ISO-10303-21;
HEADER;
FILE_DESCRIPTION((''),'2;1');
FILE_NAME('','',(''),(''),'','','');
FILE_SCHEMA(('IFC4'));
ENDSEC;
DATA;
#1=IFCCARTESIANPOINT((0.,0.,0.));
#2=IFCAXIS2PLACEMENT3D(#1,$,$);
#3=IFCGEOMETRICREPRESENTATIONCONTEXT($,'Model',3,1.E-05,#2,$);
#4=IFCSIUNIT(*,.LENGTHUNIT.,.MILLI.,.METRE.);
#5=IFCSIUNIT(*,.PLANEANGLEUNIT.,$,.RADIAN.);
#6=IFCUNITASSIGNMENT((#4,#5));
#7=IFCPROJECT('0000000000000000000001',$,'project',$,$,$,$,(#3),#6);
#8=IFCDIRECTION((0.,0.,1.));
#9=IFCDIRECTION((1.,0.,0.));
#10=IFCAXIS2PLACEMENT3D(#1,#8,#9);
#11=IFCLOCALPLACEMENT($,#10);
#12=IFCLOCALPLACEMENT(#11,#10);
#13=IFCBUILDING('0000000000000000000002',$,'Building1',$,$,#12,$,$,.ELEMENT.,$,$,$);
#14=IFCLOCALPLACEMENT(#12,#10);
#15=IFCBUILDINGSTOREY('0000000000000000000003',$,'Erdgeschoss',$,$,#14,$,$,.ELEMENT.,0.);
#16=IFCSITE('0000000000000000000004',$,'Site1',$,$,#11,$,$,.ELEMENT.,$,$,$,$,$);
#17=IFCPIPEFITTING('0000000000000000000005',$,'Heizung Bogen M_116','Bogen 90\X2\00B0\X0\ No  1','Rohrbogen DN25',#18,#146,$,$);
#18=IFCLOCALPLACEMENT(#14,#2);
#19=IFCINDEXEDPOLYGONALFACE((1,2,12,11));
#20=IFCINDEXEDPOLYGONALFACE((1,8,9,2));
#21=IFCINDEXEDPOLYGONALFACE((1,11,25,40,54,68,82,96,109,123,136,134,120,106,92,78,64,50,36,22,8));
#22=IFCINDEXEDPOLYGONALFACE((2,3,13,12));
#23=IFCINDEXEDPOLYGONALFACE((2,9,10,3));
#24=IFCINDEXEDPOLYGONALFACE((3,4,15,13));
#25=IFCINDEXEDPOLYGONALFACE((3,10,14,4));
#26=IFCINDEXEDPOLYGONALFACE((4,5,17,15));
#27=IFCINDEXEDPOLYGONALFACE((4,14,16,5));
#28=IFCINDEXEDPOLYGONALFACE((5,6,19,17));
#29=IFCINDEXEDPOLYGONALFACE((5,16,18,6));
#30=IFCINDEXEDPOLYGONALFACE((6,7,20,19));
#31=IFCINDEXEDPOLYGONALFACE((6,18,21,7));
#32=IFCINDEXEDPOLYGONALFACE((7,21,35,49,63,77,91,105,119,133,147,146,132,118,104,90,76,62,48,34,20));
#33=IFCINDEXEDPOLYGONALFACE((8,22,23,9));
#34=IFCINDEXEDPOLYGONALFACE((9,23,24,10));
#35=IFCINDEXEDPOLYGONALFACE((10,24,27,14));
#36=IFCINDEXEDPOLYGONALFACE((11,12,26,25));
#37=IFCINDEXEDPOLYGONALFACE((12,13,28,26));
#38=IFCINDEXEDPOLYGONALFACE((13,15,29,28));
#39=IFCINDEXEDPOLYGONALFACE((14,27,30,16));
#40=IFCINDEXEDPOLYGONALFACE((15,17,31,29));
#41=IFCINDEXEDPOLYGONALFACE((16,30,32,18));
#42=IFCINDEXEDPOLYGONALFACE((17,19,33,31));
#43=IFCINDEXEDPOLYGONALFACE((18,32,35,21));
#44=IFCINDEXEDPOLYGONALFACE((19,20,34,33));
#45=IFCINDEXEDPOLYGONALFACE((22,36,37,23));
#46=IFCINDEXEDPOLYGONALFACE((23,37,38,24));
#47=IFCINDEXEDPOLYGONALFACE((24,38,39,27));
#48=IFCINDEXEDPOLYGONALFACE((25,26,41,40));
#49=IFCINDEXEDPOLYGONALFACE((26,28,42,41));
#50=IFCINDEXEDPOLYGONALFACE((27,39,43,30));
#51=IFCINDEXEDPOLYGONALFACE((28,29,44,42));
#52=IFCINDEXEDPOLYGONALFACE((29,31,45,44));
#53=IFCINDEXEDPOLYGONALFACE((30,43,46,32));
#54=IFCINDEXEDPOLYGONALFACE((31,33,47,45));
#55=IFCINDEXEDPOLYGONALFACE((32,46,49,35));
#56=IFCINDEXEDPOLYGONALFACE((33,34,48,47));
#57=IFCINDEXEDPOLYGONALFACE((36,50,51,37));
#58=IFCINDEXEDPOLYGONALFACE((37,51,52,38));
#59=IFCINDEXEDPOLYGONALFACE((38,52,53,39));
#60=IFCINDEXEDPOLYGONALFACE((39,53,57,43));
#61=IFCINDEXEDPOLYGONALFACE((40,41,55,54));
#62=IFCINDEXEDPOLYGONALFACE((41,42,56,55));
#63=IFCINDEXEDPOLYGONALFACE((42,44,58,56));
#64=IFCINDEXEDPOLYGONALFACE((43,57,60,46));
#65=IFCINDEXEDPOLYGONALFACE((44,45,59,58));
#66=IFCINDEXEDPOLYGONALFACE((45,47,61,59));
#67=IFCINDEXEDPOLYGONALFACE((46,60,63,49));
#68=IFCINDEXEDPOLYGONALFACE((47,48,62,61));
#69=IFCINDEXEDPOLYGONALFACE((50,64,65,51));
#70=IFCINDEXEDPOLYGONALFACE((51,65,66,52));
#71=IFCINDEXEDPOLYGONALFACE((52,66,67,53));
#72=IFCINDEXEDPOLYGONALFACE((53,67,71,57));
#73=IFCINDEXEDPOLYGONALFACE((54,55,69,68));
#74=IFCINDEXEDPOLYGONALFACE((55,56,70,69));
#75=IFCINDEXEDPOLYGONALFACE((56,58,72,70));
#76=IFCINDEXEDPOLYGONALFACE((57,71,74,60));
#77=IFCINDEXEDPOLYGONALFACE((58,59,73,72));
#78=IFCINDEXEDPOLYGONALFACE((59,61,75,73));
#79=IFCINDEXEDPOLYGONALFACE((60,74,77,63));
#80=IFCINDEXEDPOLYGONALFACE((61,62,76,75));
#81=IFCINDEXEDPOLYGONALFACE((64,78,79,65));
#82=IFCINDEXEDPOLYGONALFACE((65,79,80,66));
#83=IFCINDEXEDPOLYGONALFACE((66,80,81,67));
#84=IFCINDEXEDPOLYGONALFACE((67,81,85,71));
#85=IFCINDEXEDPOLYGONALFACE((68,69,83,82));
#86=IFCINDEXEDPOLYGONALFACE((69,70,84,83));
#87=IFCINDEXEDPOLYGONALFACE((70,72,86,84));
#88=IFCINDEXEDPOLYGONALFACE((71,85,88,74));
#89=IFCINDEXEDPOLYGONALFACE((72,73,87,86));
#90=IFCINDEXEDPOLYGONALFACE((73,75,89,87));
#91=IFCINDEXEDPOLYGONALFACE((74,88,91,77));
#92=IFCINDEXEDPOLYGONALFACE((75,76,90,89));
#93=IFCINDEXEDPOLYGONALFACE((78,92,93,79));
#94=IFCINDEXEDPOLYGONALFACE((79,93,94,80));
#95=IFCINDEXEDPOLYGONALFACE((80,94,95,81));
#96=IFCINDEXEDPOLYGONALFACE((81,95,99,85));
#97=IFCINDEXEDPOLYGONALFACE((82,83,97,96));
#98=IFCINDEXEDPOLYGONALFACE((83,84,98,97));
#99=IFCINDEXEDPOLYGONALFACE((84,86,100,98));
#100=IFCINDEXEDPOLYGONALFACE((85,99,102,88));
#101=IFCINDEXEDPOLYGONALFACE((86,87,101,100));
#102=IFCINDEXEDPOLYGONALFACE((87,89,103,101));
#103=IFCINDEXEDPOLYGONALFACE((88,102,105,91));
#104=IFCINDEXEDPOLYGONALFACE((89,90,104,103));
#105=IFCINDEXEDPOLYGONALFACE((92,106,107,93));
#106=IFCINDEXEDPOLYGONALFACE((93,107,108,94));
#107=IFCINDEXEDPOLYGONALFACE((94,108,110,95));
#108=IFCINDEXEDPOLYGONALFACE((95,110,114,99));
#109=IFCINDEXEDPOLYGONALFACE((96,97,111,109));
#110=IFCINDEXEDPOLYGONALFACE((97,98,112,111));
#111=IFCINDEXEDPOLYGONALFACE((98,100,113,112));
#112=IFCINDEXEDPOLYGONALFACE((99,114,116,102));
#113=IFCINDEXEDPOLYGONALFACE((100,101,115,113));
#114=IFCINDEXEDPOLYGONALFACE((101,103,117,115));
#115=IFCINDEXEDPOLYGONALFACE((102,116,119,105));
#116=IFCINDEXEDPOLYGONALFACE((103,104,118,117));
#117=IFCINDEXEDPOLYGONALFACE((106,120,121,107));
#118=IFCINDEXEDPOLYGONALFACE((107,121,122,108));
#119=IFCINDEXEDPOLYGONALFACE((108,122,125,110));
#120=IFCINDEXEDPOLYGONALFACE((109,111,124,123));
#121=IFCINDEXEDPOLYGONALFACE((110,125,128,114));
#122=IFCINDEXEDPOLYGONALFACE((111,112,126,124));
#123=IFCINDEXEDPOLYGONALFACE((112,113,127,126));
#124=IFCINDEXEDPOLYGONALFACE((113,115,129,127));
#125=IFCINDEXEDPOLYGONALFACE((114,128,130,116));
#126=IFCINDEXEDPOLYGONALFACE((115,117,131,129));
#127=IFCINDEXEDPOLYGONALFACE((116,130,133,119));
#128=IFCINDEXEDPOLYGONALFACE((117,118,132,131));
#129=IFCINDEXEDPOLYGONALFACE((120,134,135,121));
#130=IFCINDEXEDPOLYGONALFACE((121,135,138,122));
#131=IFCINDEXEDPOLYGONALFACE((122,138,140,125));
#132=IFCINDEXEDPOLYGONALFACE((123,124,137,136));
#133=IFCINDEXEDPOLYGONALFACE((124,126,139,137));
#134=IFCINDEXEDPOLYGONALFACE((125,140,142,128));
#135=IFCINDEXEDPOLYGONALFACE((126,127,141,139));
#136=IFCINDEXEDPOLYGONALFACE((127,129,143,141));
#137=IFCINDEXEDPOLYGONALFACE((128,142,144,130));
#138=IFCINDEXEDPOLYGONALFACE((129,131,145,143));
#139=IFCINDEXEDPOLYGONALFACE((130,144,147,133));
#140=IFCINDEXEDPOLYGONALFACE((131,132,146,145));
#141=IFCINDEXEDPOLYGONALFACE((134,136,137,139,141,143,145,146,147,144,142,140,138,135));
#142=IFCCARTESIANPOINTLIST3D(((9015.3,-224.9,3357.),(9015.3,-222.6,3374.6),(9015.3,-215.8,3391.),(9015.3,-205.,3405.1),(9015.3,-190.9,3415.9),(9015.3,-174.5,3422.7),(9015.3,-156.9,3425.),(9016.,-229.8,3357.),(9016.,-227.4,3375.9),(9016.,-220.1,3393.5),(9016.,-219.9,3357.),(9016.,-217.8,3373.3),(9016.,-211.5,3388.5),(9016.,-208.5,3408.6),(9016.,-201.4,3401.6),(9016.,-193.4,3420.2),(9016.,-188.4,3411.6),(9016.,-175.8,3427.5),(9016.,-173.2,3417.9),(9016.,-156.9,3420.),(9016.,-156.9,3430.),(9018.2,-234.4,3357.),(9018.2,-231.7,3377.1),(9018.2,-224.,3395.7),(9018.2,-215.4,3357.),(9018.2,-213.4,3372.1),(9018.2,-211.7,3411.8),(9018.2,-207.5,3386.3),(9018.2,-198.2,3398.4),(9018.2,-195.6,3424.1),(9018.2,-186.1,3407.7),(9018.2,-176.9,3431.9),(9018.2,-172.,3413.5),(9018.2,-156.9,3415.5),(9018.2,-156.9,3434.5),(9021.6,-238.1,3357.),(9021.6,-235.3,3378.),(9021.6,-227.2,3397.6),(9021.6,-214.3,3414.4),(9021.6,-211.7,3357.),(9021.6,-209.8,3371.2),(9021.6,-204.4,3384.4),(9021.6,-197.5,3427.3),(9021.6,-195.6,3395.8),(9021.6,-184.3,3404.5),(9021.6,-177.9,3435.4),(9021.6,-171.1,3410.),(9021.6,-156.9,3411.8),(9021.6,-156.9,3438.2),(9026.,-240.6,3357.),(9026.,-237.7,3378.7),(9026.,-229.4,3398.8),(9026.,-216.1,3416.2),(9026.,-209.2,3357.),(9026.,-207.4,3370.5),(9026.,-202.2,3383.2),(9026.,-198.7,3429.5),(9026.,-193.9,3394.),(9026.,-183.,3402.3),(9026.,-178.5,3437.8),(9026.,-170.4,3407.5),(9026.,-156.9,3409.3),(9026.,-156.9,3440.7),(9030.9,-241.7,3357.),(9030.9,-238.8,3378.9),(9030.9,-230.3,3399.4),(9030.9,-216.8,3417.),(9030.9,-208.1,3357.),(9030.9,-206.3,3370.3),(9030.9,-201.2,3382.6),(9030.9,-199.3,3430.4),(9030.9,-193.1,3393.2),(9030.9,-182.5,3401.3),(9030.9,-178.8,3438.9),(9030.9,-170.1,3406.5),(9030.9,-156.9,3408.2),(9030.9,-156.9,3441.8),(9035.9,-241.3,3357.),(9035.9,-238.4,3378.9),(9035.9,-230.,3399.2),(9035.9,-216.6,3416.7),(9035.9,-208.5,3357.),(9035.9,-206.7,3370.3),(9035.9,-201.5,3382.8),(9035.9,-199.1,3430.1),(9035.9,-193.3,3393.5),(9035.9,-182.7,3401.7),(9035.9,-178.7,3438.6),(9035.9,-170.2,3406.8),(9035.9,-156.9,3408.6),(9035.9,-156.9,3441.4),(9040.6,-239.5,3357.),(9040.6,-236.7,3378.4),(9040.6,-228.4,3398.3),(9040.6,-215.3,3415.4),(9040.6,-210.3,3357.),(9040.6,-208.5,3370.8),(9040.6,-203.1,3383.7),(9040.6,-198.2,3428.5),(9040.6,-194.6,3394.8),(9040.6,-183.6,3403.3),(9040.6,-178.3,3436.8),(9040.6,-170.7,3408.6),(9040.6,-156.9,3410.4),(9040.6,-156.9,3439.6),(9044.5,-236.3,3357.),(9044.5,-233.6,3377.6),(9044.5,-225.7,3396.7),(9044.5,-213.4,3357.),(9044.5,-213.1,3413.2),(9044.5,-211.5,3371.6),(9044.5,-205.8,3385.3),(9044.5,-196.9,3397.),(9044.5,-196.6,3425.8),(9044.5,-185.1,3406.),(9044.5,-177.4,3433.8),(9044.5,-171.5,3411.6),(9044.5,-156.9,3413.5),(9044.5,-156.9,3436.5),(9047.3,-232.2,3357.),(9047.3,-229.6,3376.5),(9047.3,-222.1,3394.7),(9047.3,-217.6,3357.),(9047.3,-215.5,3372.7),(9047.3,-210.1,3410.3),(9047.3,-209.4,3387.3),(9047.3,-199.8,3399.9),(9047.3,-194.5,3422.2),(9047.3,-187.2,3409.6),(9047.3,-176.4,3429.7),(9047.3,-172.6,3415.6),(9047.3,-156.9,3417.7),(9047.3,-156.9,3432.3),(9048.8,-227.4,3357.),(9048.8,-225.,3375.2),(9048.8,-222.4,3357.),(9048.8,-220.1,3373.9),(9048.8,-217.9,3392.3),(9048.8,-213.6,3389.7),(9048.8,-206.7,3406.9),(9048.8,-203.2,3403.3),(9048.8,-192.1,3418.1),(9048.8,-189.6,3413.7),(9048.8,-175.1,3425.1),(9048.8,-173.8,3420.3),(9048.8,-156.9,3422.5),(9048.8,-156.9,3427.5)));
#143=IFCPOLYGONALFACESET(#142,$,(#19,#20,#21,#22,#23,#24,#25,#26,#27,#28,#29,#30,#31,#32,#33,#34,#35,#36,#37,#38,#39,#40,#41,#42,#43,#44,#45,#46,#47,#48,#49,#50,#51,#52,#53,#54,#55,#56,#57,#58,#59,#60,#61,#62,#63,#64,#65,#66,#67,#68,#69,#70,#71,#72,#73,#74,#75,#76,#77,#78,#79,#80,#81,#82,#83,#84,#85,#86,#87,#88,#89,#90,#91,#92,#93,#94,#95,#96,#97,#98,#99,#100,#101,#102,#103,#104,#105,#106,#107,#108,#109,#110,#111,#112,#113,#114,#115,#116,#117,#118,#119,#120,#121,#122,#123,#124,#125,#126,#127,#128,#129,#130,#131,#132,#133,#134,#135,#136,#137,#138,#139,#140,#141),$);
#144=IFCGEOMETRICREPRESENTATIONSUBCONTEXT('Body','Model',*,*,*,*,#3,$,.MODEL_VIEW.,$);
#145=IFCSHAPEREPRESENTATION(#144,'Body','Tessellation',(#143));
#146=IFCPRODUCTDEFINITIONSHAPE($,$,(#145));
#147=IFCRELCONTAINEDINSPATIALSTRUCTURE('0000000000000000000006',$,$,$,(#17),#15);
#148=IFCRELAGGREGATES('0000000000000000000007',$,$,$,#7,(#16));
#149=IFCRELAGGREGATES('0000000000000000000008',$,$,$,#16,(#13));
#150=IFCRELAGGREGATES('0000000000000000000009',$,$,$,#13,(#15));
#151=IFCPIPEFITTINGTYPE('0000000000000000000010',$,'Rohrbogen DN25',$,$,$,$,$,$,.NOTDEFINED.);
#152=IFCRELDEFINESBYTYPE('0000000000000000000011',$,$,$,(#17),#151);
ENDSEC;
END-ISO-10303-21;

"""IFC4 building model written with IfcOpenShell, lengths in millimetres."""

from ifc_helpers import new_model, entity, si_unit, frame, origin, origin_with_axes, place, context, subcontext, project, spatial, shape, source, transform, mapped, type_object, element, save


model = new_model("IFC4")

# Units and contexts
model_context = context("Model", 3, precision=1e-05, world=origin())
body_context = subcontext(model_context, "Body", "Model", "MODEL_VIEW")
ifc_project = project(units=[si_unit("LENGTHUNIT", "METRE", prefix="MILLI"), si_unit("PLANEANGLEUNIT", "RADIAN")], contexts=[model_context])

# Site, building, storey
site_placement = place(None, origin_with_axes())
site = spatial("IfcSite", under=ifc_project, at=site_placement, Name="Site1", CompositionType="ELEMENT")
building_placement = place(site_placement, origin_with_axes())
building = spatial("IfcBuilding", under=site, at=building_placement, Name="Building1", CompositionType="ELEMENT")
storey_placement = place(building_placement, origin_with_axes())
storey = spatial("IfcBuildingStorey", under=building, at=storey_placement, Name="Erdgeschoss", CompositionType="ELEMENT", Elevation=0.0)

# Pipe fitting
pipe_fitting_type = type_object("IfcPipeFittingType", Name="Rohrbogen DN25", PredefinedType="NOTDEFINED")
shared_shape_1 = source(origin_with_axes(), body_context, "Body", "SolidModel", [
    entity("IfcRevolvedAreaSolid", entity("IfcCircleProfileDef", "AREA", None, entity("IfcAxis2Placement2D", entity("IfcCartesianPoint", [0.0, 0.0]), entity("IfcDirection", [1.0, 0.0])), 16.9), entity("IfcAxis2Placement3D", entity("IfcCartesianPoint", [-42.4, 0.0, 25.6]), entity("IfcDirection", [1.0, 0.0, 0.0]), entity("IfcDirection", [0.0, -1.0, 0.0])), entity("IfcAxis1Placement", entity("IfcCartesianPoint", [0.0, 68.0, 0.0]), entity("IfcDirection", [-1.0, 0.0, 0.0])), 1.570796),
])
pipe_fitting_1_placement = place(storey_placement, frame((9032.1, -199.3, 3399.4), z_axis=(0.0, 0.0, 1.0), x_axis=(1.0, 0.0, 0.0)))
element("IfcPipeFitting", 1, at=pipe_fitting_1_placement, inside=storey, type_object=pipe_fitting_type, Name="Heizung Bogen M_116", Description="Bogen 90° No  1", ObjectType="Rohrbogen DN25", shapes=[
    shape(body_context, "Body", "MappedRepresentation", [mapped(shared_shape_1, transform((0.0, 0.0, 0.0), x_axis=(0.0, -1.0, 0.0), y_axis=(1.0, 0.0, 0.0), z_axis=(0.0, 0.0, 1.0), scale=1.0))]),
    shape(body_context, "Body", "MappedRepresentation", [mapped(shared_shape_1, transform((0.0, 0.0, 0.0), x_axis=(0.0, -1.0, 0.0), y_axis=(1.0, 0.0, 0.0), z_axis=(0.0, 0.0, 1.0), scale=1.0))]),
])

save(model, "model.ifc")
